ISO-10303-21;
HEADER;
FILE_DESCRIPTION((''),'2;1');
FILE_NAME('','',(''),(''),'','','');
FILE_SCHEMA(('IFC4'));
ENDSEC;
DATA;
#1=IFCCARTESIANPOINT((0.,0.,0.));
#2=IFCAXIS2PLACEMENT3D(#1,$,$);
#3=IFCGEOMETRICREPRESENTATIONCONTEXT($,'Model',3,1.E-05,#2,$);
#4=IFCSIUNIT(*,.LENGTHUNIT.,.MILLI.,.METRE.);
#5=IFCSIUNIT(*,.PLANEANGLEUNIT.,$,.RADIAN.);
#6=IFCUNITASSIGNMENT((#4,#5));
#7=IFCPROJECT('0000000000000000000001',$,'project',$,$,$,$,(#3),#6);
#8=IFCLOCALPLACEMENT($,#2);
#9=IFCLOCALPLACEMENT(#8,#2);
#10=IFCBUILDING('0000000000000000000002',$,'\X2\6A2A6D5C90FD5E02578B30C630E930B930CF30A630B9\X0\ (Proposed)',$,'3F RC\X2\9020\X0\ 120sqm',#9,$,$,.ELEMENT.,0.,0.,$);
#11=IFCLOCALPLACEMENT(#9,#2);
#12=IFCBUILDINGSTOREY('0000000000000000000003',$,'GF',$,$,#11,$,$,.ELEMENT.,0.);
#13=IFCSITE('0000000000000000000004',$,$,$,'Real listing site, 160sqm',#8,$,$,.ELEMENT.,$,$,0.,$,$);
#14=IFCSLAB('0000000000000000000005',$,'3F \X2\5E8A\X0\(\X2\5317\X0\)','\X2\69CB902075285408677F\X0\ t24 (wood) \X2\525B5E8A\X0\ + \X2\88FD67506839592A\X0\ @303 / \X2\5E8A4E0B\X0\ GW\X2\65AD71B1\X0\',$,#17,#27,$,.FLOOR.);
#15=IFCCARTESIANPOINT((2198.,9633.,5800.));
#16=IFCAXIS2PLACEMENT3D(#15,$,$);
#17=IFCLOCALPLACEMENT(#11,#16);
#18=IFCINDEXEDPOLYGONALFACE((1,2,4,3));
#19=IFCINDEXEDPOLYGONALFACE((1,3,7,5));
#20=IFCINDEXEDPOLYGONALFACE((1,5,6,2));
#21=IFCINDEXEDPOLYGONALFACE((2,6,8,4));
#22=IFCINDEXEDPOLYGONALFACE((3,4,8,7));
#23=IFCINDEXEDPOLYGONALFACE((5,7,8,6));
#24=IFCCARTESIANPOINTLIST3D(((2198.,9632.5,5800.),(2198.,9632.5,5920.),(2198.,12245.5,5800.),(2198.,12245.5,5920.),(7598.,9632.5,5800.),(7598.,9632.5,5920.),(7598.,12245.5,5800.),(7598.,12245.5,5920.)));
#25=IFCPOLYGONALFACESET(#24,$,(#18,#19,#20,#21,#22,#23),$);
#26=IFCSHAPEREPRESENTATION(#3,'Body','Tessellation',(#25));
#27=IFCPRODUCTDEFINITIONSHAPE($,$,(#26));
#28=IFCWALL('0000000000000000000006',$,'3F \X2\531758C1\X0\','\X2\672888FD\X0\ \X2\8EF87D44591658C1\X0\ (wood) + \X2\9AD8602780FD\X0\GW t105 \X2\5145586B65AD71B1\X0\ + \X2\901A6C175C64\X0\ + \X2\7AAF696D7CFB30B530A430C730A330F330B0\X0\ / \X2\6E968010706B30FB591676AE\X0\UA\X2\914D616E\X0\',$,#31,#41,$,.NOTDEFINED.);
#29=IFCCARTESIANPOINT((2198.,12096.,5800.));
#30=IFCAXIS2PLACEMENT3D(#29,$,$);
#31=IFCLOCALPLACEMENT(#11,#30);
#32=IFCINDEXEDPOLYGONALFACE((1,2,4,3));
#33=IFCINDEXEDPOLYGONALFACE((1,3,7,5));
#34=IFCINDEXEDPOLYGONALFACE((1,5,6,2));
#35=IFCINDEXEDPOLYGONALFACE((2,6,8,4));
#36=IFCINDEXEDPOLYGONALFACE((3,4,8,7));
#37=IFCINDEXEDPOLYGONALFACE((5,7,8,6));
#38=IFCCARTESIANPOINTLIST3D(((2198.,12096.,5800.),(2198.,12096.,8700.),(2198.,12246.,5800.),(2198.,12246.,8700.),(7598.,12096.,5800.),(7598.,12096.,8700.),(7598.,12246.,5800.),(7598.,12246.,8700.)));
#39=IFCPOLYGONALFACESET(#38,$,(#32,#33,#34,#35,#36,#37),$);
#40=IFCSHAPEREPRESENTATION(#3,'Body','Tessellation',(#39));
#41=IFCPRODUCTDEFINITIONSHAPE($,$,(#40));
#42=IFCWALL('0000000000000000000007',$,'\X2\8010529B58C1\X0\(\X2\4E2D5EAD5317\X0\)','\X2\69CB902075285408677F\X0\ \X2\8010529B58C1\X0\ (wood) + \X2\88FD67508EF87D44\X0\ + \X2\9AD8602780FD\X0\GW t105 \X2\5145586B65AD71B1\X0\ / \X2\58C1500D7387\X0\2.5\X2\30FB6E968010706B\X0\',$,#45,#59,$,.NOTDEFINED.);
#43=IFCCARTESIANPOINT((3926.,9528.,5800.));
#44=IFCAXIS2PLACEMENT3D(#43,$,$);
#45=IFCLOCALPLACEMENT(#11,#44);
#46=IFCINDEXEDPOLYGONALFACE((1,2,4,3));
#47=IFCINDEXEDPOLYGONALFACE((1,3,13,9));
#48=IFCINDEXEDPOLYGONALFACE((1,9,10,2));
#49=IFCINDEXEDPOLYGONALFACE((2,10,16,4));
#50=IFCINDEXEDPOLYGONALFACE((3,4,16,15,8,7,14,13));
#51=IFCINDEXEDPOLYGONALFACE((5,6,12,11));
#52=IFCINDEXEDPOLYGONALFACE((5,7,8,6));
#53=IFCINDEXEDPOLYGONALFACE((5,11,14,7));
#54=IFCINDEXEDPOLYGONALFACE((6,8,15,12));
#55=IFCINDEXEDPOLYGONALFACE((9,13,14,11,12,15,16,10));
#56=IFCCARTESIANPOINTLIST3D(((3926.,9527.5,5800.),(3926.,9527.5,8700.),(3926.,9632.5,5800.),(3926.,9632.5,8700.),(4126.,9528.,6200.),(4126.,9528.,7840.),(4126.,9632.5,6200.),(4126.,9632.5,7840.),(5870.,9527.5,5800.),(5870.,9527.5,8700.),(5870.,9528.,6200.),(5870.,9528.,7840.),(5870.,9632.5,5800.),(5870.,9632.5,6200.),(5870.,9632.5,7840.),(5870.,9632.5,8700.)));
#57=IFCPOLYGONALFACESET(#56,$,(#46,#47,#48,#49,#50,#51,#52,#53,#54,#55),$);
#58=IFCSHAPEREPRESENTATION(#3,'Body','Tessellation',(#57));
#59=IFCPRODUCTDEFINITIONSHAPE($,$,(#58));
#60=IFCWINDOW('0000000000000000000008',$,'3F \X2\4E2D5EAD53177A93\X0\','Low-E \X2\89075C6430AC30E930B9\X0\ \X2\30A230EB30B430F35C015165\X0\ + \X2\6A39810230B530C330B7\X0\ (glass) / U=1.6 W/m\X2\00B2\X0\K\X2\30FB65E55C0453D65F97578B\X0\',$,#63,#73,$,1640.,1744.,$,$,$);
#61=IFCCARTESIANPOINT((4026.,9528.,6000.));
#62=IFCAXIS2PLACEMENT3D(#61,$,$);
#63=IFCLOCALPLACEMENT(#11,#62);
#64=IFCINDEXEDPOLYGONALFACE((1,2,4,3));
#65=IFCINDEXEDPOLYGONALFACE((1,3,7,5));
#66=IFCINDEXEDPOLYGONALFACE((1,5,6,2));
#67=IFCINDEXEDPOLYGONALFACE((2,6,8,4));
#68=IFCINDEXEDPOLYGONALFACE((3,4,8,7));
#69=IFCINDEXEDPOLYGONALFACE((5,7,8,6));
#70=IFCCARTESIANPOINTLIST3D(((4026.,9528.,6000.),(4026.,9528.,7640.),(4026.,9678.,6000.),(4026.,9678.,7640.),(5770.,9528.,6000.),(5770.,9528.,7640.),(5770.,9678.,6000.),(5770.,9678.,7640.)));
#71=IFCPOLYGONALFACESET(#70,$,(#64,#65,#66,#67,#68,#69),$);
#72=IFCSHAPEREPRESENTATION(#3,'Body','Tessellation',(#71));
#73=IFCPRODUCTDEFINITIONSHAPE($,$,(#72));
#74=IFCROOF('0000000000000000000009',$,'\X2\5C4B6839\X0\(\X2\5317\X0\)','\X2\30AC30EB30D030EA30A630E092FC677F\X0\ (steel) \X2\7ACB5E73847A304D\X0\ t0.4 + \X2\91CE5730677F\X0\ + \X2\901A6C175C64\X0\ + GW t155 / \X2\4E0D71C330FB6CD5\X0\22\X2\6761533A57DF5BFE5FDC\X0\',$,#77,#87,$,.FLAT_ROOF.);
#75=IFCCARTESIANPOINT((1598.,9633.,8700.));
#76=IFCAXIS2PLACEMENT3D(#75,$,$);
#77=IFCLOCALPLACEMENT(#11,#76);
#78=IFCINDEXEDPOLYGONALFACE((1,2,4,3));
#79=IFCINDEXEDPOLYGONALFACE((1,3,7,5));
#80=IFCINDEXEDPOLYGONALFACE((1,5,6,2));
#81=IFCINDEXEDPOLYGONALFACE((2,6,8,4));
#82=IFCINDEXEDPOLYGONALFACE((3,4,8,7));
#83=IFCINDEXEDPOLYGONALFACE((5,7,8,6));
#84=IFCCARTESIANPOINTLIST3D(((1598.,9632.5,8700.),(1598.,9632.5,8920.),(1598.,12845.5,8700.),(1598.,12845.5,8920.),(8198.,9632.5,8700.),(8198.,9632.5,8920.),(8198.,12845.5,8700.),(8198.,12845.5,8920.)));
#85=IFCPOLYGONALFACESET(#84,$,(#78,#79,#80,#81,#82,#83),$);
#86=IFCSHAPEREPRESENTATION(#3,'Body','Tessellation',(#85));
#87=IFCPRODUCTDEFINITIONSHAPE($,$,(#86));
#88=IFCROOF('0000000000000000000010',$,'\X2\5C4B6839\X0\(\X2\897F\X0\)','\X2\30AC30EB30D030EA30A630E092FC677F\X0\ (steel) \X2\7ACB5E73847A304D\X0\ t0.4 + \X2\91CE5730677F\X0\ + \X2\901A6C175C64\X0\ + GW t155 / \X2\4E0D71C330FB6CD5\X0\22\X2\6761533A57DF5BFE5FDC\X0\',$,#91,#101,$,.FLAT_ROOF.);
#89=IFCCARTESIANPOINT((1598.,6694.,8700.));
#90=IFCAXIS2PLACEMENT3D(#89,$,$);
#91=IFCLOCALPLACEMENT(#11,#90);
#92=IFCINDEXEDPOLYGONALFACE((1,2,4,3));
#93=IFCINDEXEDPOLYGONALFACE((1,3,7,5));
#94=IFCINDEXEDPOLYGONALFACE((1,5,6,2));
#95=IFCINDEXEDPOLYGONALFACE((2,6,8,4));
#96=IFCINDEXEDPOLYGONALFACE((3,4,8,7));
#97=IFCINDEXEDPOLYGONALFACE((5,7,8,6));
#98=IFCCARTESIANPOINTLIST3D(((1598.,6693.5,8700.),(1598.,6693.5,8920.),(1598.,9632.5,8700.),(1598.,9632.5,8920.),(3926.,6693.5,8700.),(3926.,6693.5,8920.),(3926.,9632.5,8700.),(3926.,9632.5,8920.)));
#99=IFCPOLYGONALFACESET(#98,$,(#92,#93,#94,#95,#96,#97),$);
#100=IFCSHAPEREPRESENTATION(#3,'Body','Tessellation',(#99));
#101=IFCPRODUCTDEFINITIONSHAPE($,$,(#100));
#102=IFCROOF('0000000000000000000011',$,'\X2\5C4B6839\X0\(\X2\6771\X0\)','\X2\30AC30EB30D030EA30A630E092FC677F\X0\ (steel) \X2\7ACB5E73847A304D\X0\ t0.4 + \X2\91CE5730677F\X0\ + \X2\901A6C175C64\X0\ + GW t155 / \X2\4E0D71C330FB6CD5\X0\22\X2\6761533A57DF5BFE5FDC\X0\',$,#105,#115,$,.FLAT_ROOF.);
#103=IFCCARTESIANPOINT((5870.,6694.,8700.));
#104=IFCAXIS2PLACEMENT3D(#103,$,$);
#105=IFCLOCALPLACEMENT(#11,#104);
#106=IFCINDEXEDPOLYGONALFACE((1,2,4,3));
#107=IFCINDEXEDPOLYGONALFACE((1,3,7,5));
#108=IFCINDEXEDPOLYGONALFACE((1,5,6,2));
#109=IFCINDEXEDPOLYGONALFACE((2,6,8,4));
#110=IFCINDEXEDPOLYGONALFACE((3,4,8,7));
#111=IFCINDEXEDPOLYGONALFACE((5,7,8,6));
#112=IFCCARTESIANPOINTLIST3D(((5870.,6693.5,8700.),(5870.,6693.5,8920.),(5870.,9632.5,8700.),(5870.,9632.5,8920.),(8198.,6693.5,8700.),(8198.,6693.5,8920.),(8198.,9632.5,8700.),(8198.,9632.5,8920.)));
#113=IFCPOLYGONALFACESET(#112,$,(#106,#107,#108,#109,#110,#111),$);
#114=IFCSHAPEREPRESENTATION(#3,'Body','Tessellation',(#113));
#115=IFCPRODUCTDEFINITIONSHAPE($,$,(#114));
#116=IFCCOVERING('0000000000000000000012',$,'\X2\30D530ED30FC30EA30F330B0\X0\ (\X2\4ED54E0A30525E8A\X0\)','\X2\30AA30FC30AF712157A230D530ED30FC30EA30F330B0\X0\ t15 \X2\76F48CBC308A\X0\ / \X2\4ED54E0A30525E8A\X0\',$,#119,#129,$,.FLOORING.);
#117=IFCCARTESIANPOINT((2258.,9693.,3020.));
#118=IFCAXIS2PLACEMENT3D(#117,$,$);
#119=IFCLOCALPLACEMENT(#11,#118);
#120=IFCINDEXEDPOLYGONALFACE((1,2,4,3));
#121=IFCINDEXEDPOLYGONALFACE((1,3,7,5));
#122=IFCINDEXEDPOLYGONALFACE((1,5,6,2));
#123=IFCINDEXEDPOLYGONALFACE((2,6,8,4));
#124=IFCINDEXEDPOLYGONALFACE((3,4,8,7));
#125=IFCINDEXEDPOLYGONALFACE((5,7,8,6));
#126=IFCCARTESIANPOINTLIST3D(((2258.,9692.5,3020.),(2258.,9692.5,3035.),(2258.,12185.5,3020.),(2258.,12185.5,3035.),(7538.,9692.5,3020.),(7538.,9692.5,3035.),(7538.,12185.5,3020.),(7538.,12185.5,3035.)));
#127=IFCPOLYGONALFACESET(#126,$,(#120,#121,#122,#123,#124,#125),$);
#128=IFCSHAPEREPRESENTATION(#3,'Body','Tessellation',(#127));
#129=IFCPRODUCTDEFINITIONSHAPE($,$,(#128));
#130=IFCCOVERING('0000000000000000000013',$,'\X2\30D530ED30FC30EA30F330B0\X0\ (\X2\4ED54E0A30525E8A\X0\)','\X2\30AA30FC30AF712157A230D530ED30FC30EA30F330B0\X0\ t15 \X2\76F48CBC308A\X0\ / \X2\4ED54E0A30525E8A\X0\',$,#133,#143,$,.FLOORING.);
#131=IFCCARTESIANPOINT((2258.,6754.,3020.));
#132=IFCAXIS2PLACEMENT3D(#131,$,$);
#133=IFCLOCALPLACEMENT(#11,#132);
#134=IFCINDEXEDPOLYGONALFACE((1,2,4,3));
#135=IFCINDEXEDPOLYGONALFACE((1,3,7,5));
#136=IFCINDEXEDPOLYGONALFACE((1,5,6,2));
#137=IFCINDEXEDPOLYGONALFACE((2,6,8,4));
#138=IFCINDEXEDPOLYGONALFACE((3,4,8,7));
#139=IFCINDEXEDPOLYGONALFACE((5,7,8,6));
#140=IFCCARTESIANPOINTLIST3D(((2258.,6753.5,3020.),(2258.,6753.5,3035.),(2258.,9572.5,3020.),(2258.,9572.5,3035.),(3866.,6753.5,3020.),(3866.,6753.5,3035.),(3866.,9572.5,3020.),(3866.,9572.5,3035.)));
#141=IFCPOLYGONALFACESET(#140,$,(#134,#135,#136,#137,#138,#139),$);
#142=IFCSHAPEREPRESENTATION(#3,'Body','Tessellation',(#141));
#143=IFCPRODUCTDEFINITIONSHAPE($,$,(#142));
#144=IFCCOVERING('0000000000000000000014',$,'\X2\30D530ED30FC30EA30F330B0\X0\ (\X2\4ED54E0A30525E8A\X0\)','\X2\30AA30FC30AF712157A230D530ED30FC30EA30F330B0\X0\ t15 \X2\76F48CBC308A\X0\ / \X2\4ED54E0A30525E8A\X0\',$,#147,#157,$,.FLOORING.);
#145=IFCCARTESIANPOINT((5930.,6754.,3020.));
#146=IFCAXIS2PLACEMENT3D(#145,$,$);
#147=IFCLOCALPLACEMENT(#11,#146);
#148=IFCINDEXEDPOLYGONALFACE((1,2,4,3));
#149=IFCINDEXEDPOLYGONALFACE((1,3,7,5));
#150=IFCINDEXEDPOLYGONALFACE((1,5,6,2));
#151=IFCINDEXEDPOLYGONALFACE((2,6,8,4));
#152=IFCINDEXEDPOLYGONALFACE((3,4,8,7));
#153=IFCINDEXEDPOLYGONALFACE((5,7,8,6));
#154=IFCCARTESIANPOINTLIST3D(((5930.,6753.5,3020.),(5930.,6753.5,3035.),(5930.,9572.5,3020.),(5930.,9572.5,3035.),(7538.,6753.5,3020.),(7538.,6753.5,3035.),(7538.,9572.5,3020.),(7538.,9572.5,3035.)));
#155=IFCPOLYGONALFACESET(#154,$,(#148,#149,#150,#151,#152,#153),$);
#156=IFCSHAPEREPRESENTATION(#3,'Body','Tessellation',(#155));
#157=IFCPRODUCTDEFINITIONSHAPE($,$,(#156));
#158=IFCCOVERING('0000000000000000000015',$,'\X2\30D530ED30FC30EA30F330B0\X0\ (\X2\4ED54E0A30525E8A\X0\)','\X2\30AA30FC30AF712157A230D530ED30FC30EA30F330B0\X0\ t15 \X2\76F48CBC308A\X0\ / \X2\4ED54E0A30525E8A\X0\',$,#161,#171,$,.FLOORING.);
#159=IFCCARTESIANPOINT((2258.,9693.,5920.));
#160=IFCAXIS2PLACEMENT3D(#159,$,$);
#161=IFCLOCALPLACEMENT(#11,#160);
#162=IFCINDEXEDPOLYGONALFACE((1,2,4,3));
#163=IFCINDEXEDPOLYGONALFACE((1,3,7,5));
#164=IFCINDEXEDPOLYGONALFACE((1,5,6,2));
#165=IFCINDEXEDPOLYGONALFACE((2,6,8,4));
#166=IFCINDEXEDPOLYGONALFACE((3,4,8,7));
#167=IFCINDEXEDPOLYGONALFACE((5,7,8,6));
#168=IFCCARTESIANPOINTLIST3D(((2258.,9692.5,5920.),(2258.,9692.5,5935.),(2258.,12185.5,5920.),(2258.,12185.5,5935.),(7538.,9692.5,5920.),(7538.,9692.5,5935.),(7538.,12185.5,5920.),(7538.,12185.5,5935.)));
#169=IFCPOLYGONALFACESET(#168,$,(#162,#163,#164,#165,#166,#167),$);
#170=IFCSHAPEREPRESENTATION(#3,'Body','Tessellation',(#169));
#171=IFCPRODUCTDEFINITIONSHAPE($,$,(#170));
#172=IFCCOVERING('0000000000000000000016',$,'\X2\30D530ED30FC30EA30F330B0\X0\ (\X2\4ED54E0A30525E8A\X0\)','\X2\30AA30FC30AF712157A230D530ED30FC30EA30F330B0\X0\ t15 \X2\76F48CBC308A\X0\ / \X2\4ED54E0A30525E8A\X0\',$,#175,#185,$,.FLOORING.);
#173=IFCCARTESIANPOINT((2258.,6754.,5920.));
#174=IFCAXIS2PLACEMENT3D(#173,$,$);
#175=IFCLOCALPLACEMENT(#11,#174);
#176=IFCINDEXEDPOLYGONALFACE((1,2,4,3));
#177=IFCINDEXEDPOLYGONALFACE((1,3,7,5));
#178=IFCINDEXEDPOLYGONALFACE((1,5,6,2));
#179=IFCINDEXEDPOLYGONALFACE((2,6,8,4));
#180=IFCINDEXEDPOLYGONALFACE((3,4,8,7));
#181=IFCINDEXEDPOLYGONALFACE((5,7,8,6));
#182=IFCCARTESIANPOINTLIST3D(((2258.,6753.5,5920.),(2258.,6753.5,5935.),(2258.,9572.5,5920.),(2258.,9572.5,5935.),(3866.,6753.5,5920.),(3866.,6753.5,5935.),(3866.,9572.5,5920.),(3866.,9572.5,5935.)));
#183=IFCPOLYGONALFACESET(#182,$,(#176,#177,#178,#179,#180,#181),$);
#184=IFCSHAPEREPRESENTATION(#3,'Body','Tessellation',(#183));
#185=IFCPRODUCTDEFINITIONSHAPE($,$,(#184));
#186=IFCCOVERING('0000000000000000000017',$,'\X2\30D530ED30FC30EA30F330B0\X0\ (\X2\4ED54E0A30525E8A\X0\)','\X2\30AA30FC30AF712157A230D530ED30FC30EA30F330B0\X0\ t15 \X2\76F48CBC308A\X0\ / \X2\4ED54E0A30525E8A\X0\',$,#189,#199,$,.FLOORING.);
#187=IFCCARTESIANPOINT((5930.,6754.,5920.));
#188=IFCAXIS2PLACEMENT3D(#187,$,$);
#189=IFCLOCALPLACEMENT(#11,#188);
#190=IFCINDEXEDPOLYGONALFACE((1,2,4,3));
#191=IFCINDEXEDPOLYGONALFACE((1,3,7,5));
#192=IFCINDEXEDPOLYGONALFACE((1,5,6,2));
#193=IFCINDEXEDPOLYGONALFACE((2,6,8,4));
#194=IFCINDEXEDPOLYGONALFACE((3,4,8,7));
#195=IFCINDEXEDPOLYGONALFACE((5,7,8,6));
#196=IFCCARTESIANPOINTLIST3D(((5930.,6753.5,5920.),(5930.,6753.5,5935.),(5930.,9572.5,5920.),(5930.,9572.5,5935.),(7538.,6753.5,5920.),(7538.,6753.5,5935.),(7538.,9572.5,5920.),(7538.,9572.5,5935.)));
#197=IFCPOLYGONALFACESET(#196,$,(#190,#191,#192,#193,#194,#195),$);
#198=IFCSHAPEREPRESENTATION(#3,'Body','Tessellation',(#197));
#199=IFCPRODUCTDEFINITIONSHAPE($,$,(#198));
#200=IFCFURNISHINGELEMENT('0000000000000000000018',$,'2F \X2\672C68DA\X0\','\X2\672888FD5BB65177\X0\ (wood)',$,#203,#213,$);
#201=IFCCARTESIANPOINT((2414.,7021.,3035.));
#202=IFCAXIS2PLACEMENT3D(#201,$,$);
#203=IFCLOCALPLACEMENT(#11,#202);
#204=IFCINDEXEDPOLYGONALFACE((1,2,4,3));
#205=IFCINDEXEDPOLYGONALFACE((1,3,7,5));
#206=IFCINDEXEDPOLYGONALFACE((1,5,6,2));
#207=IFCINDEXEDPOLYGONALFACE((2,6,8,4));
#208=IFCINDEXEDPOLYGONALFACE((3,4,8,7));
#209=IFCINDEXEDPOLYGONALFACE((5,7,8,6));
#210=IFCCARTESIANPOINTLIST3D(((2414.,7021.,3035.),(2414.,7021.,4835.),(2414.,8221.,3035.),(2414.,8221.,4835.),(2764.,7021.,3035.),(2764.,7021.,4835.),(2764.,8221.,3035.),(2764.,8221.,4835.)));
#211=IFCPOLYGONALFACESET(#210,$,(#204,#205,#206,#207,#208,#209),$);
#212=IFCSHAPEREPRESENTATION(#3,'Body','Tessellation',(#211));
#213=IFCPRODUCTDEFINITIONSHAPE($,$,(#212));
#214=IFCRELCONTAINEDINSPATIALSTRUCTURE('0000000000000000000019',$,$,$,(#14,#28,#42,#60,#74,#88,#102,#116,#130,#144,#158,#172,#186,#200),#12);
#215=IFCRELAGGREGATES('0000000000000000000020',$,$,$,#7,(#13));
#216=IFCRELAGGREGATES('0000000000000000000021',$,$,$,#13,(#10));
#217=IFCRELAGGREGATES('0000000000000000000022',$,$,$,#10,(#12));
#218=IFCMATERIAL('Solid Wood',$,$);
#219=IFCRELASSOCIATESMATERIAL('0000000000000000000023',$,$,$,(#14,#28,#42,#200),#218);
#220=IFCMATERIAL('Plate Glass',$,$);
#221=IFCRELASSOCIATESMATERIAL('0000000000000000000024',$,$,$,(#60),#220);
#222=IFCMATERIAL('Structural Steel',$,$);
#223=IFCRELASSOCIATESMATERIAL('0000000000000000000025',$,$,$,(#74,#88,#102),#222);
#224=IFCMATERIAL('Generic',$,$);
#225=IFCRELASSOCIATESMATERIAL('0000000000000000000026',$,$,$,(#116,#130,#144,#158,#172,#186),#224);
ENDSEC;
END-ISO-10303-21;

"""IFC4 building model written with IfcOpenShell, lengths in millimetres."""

from ifc_helpers import new_model, si_unit, frame, frame_2d, origin, place, context, project, spatial, rectangle, extrude, material, element, fill, save


model = new_model("IFC4")

# Units and contexts
model_context = context("Model", 3, precision=1e-05, world=origin())
ifc_project = project(units=[si_unit("LENGTHUNIT", "METRE", prefix="MILLI"), si_unit("PLANEANGLEUNIT", "RADIAN")], contexts=[model_context])

# Site, building, storey
site_placement = place(None, origin())
site = spatial("IfcSite", under=ifc_project, at=site_placement, ObjectType="Real listing site, 160sqm", CompositionType="ELEMENT", RefElevation=0.0)
building_placement = place(site_placement, origin())
building = spatial("IfcBuilding", under=site, at=building_placement, Name="横浜都市型テラスハウス (Proposed)", ObjectType="3F RC造 120sqm", CompositionType="ELEMENT", ElevationOfRefHeight=0.0, ElevationOfTerrain=0.0)
storey_placement = place(building_placement, origin())
storey = spatial("IfcBuildingStorey", under=building, at=storey_placement, Name="GF", CompositionType="ELEMENT", Elevation=0.0)

# Slab
ifc_material_1 = material(Name="Solid Wood")
slab_placement = place(storey_placement, frame((2198.0, 9633.0, 5800.0)))
element("IfcSlab", 1, at=slab_placement, inside=storey, material=ifc_material_1, Name="3F 床(北)", Description="構造用合板 t24 (wood) 剛床 + 製材根太 @303 / 床下 GW断熱", PredefinedType="FLOOR", context=model_context, shape_type="SweptSolid", body=[
    extrude(rectangle(XDim=5400.0, YDim=2613.0, at=frame_2d((2700.0, 1306.0))), frame((2198.0, 9633.0, 5800.0)), (0.0, 0.0, 1.0), 120.0),
])

# Wall
wall_1_placement = place(storey_placement, frame((2198.0, 12096.0, 5800.0)))
element("IfcWall", 2, at=wall_1_placement, inside=storey, material=ifc_material_1, Name="3F 北壁", Description="木製 軸組外壁 (wood) + 高性能GW t105 充填断熱 + 通気層 + 窯業系サイディング / 準耐火・外皮UA配慮", PredefinedType="NOTDEFINED", context=model_context, shape_type="SweptSolid", body=[
    extrude(rectangle(XDim=5400.0, YDim=150.0, at=frame_2d((2700.0, 75.0))), frame((2198.0, 12096.0, 5800.0)), (0.0, 0.0, 1.0), 2900.0),
])

# Wall, opening, window
wall_2_placement = place(storey_placement, frame((3926.0, 9528.0, 5800.0)))
wall_2 = element("IfcWall", 3, at=wall_2_placement, inside=storey, material=ifc_material_1, Name="耐力壁(中庭北)", Description="構造用合板 耐力壁 (wood) + 製材軸組 + 高性能GW t105 充填断熱 / 壁倍率2.5・準耐火", PredefinedType="NOTDEFINED", context=model_context, shape_type="SweptSolid", body=[
    extrude(rectangle(XDim=1944.0, YDim=105.0, at=frame_2d((972.0, 52.0))), frame((3926.0, 9528.0, 5800.0)), (0.0, 0.0, 1.0), 2900.0),
])
opening_placement = place(storey_placement, frame((4026.0, 9528.0, 6000.0)))
opening = element("IfcOpeningElement", 4, at=opening_placement, cuts=wall_2, PredefinedType="NOTDEFINED", context=model_context, shape_type="SweptSolid", body=[
    extrude(rectangle(XDim=1744.0, YDim=150.0, at=frame_2d((872.0, 75.0))), frame((4026.0, 9528.0, 6000.0)), (0.0, 0.0, 1.0), 1640.0),
])
ifc_material_2 = material(Name="Plate Glass")
window_placement = place(storey_placement, frame((4026.0, 9528.0, 6000.0)))
window = element("IfcWindow", 5, at=window_placement, inside=storey, material=ifc_material_2, Name="3F 中庭北窓", Description="Low-E 複層ガラス アルゴン封入 + 樹脂サッシ (glass) / U=1.6 W/m²K・日射取得型", OverallHeight=1640.0, OverallWidth=1744.0, context=model_context, shape_type="SweptSolid", body=[
    extrude(rectangle(XDim=1744.0, YDim=150.0, at=frame_2d((872.0, 75.0))), frame((4026.0, 9528.0, 6000.0)), (0.0, 0.0, 1.0), 1640.0),
])
fill(opening, window)

# Roofs
ifc_material_3 = material(Name="Structural Steel")
roof_1_placement = place(storey_placement, frame((1598.0, 9633.0, 8700.0)))
element("IfcRoof", 6, at=roof_1_placement, inside=storey, material=ifc_material_3, Name="屋根(北)", Description="ガルバリウム鋼板 (steel) 立平葺き t0.4 + 野地板 + 通気層 + GW t155 / 不燃・法22条区域対応", PredefinedType="FLAT_ROOF", context=model_context, shape_type="SweptSolid", body=[
    extrude(rectangle(XDim=6600.0, YDim=3213.0, at=frame_2d((3300.0, 1606.0))), frame((1598.0, 9633.0, 8700.0)), (0.0, 0.0, 1.0), 220.0),
])
roof_2_placement = place(storey_placement, frame((1598.0, 6694.0, 8700.0)))
element("IfcRoof", 7, at=roof_2_placement, inside=storey, material=ifc_material_3, Name="屋根(西)", Description="ガルバリウム鋼板 (steel) 立平葺き t0.4 + 野地板 + 通気層 + GW t155 / 不燃・法22条区域対応", PredefinedType="FLAT_ROOF", context=model_context, shape_type="SweptSolid", body=[
    extrude(rectangle(XDim=2328.0, YDim=2939.0, at=frame_2d((1164.0, 1469.0))), frame((1598.0, 6694.0, 8700.0)), (0.0, 0.0, 1.0), 220.0),
])
roof_3_placement = place(storey_placement, frame((5870.0, 6694.0, 8700.0)))
element("IfcRoof", 8, at=roof_3_placement, inside=storey, material=ifc_material_3, Name="屋根(東)", Description="ガルバリウム鋼板 (steel) 立平葺き t0.4 + 野地板 + 通気層 + GW t155 / 不燃・法22条区域対応", PredefinedType="FLAT_ROOF", context=model_context, shape_type="SweptSolid", body=[
    extrude(rectangle(XDim=2328.0, YDim=2939.0, at=frame_2d((1164.0, 1469.0))), frame((5870.0, 6694.0, 8700.0)), (0.0, 0.0, 1.0), 220.0),
])

# Coverings
ifc_material_4 = material(Name="Generic")
covering_1_placement = place(storey_placement, frame((2258.0, 9693.0, 3020.0)))
element("IfcCovering", 9, at=covering_1_placement, inside=storey, material=ifc_material_4, Name="フローリング (仕上げ床)", Description="オーク無垢フローリング t15 直貼り / 仕上げ床", PredefinedType="FLOORING", context=model_context, shape_type="SweptSolid", body=[
    extrude(rectangle(XDim=5280.0, YDim=2493.0, at=frame_2d((2640.0, 1246.0))), frame((2258.0, 9693.0, 3020.0)), (0.0, 0.0, 1.0), 15.0),
])
covering_2_placement = place(storey_placement, frame((2258.0, 6754.0, 3020.0)))
element("IfcCovering", 10, at=covering_2_placement, inside=storey, material=ifc_material_4, Name="フローリング (仕上げ床)", Description="オーク無垢フローリング t15 直貼り / 仕上げ床", PredefinedType="FLOORING", context=model_context, shape_type="SweptSolid", body=[
    extrude(rectangle(XDim=1608.0, YDim=2819.0, at=frame_2d((804.0, 1409.0))), frame((2258.0, 6754.0, 3020.0)), (0.0, 0.0, 1.0), 15.0),
])
covering_3_placement = place(storey_placement, frame((5930.0, 6754.0, 3020.0)))
element("IfcCovering", 11, at=covering_3_placement, inside=storey, material=ifc_material_4, Name="フローリング (仕上げ床)", Description="オーク無垢フローリング t15 直貼り / 仕上げ床", PredefinedType="FLOORING", context=model_context, shape_type="SweptSolid", body=[
    extrude(rectangle(XDim=1608.0, YDim=2819.0, at=frame_2d((804.0, 1409.0))), frame((5930.0, 6754.0, 3020.0)), (0.0, 0.0, 1.0), 15.0),
])
covering_4_placement = place(storey_placement, frame((2258.0, 9693.0, 5920.0)))
element("IfcCovering", 12, at=covering_4_placement, inside=storey, material=ifc_material_4, Name="フローリング (仕上げ床)", Description="オーク無垢フローリング t15 直貼り / 仕上げ床", PredefinedType="FLOORING", context=model_context, shape_type="SweptSolid", body=[
    extrude(rectangle(XDim=5280.0, YDim=2493.0, at=frame_2d((2640.0, 1246.0))), frame((2258.0, 9693.0, 5920.0)), (0.0, 0.0, 1.0), 15.0),
])
covering_5_placement = place(storey_placement, frame((2258.0, 6754.0, 5920.0)))
element("IfcCovering", 13, at=covering_5_placement, inside=storey, material=ifc_material_4, Name="フローリング (仕上げ床)", Description="オーク無垢フローリング t15 直貼り / 仕上げ床", PredefinedType="FLOORING", context=model_context, shape_type="SweptSolid", body=[
    extrude(rectangle(XDim=1608.0, YDim=2819.0, at=frame_2d((804.0, 1409.0))), frame((2258.0, 6754.0, 5920.0)), (0.0, 0.0, 1.0), 15.0),
])
covering_6_placement = place(storey_placement, frame((5930.0, 6754.0, 5920.0)))
element("IfcCovering", 14, at=covering_6_placement, inside=storey, material=ifc_material_4, Name="フローリング (仕上げ床)", Description="オーク無垢フローリング t15 直貼り / 仕上げ床", PredefinedType="FLOORING", context=model_context, shape_type="SweptSolid", body=[
    extrude(rectangle(XDim=1608.0, YDim=2819.0, at=frame_2d((804.0, 1409.0))), frame((5930.0, 6754.0, 5920.0)), (0.0, 0.0, 1.0), 15.0),
])

# Furnishing element
furnishing_1_placement = place(storey_placement, frame((2414.0, 7021.0, 3035.0)))
element("IfcFurnishingElement", 15, at=furnishing_1_placement, inside=storey, material=ifc_material_1, Name="2F 本棚", Description="木製家具 (wood)", context=model_context, shape_type="SweptSolid", body=[
    extrude(rectangle(XDim=350.0, YDim=1200.0, at=frame_2d((175.0, 600.0))), frame((2414.0, 7021.0, 3035.0)), (0.0, 0.0, 1.0), 1800.0),
])

save(model, "model.ifc")
